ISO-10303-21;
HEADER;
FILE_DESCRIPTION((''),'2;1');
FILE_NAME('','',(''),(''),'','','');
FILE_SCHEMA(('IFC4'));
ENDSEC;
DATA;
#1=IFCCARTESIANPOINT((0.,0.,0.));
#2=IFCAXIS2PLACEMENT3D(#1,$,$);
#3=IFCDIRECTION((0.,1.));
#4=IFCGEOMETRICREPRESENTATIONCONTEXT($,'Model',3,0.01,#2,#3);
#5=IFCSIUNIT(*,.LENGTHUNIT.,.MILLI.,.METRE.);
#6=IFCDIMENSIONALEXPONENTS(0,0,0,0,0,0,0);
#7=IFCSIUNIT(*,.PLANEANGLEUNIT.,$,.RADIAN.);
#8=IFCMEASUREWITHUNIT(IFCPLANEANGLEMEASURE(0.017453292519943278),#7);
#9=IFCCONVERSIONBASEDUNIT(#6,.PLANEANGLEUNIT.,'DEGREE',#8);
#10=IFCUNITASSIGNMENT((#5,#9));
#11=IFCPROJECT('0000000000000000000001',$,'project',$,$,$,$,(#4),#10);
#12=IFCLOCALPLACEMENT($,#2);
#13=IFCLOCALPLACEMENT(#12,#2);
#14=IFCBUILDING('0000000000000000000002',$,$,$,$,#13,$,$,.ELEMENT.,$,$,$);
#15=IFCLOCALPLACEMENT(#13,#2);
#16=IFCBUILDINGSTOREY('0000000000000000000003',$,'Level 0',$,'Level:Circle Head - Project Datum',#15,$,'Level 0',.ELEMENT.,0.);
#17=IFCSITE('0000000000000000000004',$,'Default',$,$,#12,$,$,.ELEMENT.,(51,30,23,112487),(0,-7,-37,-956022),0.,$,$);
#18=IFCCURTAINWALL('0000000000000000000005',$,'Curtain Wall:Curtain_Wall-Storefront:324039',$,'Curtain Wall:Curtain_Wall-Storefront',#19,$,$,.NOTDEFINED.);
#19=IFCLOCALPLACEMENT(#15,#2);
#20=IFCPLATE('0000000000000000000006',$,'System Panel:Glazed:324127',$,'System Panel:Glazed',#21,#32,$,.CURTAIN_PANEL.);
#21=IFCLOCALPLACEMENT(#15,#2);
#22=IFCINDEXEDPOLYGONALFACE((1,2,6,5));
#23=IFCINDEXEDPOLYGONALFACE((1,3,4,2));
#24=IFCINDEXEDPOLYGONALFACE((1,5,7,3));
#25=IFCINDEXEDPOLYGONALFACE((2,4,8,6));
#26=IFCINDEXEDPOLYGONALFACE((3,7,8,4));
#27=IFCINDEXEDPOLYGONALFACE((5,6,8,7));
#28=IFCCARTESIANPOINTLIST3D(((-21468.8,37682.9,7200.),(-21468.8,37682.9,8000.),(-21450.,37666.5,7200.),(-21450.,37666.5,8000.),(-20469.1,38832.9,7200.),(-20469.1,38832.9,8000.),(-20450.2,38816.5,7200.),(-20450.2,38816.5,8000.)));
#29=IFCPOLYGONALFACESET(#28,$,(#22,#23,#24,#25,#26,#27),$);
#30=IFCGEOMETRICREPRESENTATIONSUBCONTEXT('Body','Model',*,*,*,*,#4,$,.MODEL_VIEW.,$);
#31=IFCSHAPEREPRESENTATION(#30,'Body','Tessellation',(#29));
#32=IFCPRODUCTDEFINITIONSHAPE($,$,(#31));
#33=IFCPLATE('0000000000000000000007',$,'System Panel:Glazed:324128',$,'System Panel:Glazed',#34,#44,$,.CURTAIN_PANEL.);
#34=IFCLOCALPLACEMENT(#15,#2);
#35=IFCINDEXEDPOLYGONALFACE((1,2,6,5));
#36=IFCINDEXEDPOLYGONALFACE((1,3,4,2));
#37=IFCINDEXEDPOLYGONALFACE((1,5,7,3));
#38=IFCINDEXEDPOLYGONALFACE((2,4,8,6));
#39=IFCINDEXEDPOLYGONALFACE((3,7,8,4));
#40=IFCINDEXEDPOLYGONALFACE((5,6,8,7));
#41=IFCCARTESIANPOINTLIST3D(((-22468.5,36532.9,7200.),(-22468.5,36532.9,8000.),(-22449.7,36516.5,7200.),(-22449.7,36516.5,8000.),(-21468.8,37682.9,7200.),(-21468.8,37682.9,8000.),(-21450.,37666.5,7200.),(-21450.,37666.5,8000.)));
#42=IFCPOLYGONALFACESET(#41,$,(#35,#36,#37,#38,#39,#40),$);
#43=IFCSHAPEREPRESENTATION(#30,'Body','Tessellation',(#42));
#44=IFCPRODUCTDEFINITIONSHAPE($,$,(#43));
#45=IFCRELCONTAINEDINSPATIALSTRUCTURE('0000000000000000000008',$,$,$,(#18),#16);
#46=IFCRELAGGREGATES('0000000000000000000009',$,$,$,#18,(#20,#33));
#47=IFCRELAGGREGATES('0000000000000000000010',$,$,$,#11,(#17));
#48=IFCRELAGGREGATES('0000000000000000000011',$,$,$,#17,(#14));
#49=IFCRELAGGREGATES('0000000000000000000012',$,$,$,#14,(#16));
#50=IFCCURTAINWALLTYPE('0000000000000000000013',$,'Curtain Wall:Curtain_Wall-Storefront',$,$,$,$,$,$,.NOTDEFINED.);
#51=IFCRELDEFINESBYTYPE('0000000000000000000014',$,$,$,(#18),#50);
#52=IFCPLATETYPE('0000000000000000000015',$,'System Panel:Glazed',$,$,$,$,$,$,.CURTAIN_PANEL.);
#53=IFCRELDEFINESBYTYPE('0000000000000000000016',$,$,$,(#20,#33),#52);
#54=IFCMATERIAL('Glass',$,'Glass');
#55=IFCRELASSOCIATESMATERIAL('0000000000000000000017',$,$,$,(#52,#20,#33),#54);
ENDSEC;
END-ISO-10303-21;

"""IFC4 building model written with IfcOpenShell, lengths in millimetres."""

from ifc_helpers import new_model, entity, si_unit, converted_unit, direction, frame, origin, place, context, subcontext, project, spatial, indexed_curve, outline, extrude, source, transform, mapped, material, type_object, type_shapes, element, aggregate, save


model = new_model("IFC4")

# Units and contexts
model_context = context("Model", 3, precision=0.01, world=origin(), true_north=direction((0.0, 1.0)))
body_context = subcontext(model_context, "Body", "Model", "MODEL_VIEW")
ifc_project = project(units=[si_unit("LENGTHUNIT", "METRE", prefix="MILLI"), converted_unit("PLANEANGLEUNIT", "DEGREE", entity("IfcPlaneAngleMeasure", 0.017453292519943278), si_unit("PLANEANGLEUNIT", "RADIAN"), dimensions=[0, 0, 0, 0, 0, 0, 0])], contexts=[model_context])

# Site, building, storey
site_placement = place(None, origin())
site = spatial("IfcSite", under=ifc_project, at=site_placement, Name="Default", CompositionType="ELEMENT", RefLatitude=(51, 30, 23, 112487), RefLongitude=(0, -7, -37, -956022), RefElevation=0.0)
building_placement = place(site_placement, origin())
building = spatial("IfcBuilding", under=site, at=building_placement, CompositionType="ELEMENT")
storey_placement = place(building_placement, origin())
storey = spatial("IfcBuildingStorey", under=building, at=storey_placement, Name="Level 0", ObjectType="Level:Circle Head - Project Datum", LongName="Level 0", CompositionType="ELEMENT", Elevation=0.0)

# Curtain wall, plates
curtain_wall_type = type_object("IfcCurtainWallType", Name="Curtain Wall:Curtain_Wall-Storefront", PredefinedType="NOTDEFINED")
curtain_wall_placement = place(storey_placement, origin())
curtain_wall = element("IfcCurtainWall", 1, at=curtain_wall_placement, inside=storey, type_object=curtain_wall_type, Name="Curtain Wall:Curtain_Wall-Storefront:324039", ObjectType="Curtain Wall:Curtain_Wall-Storefront", PredefinedType="NOTDEFINED")
ifc_material_1 = material(Name="Glass", Category="Glass")
plate_type_1 = type_object("IfcPlateType", Name="System Panel:Glazed", PredefinedType="CURTAIN_PANEL", material=ifc_material_1)
shared_shape_1 = source(origin(), body_context, "Body", "SweptSolid", [
    extrude(outline(indexed_curve([(-12.5, -761.9), (12.5, -761.9), (12.5, 761.9), (-12.5, 761.9), (-12.5, -761.9)], self_intersect=False)), frame((0.0, 37.0, 0.0), z_axis=(0.0, 0.0, 1.0), x_axis=(0.0, 1.0, 0.0)), (0.0, 0.0, 1.0), 800.0),
])
type_shapes(plate_type_1, [shared_shape_1])
plate_1_placement = place(curtain_wall_placement, frame((-20987.5, 38274.0, 7200.0), z_axis=(0.0, 0.0, 1.0), x_axis=(-0.656059, -0.75471, 0.0)))
plate_1 = element("IfcPlate", 2, at=plate_1_placement, type_object=plate_type_1, material=ifc_material_1, Name="System Panel:Glazed:324127", ObjectType="System Panel:Glazed", PredefinedType="CURTAIN_PANEL", context=body_context, shape_type="MappedRepresentation", body=[
    mapped(shared_shape_1, transform((0.0, 0.0, 0.0), scale=1.0)),
])
plate_2_placement = place(curtain_wall_placement, frame((-21987.2, 37124.0, 7200.0), z_axis=(0.0, 0.0, 1.0), x_axis=(-0.656059, -0.75471, 0.0)))
plate_2 = element("IfcPlate", 3, at=plate_2_placement, type_object=plate_type_1, material=ifc_material_1, Name="System Panel:Glazed:324128", ObjectType="System Panel:Glazed", PredefinedType="CURTAIN_PANEL", context=body_context, shape_type="MappedRepresentation", body=[
    mapped(shared_shape_1, transform((0.0, 0.0, 0.0), scale=1.0)),
])
aggregate(curtain_wall, [plate_1, plate_2])

save(model, "model.ifc")
